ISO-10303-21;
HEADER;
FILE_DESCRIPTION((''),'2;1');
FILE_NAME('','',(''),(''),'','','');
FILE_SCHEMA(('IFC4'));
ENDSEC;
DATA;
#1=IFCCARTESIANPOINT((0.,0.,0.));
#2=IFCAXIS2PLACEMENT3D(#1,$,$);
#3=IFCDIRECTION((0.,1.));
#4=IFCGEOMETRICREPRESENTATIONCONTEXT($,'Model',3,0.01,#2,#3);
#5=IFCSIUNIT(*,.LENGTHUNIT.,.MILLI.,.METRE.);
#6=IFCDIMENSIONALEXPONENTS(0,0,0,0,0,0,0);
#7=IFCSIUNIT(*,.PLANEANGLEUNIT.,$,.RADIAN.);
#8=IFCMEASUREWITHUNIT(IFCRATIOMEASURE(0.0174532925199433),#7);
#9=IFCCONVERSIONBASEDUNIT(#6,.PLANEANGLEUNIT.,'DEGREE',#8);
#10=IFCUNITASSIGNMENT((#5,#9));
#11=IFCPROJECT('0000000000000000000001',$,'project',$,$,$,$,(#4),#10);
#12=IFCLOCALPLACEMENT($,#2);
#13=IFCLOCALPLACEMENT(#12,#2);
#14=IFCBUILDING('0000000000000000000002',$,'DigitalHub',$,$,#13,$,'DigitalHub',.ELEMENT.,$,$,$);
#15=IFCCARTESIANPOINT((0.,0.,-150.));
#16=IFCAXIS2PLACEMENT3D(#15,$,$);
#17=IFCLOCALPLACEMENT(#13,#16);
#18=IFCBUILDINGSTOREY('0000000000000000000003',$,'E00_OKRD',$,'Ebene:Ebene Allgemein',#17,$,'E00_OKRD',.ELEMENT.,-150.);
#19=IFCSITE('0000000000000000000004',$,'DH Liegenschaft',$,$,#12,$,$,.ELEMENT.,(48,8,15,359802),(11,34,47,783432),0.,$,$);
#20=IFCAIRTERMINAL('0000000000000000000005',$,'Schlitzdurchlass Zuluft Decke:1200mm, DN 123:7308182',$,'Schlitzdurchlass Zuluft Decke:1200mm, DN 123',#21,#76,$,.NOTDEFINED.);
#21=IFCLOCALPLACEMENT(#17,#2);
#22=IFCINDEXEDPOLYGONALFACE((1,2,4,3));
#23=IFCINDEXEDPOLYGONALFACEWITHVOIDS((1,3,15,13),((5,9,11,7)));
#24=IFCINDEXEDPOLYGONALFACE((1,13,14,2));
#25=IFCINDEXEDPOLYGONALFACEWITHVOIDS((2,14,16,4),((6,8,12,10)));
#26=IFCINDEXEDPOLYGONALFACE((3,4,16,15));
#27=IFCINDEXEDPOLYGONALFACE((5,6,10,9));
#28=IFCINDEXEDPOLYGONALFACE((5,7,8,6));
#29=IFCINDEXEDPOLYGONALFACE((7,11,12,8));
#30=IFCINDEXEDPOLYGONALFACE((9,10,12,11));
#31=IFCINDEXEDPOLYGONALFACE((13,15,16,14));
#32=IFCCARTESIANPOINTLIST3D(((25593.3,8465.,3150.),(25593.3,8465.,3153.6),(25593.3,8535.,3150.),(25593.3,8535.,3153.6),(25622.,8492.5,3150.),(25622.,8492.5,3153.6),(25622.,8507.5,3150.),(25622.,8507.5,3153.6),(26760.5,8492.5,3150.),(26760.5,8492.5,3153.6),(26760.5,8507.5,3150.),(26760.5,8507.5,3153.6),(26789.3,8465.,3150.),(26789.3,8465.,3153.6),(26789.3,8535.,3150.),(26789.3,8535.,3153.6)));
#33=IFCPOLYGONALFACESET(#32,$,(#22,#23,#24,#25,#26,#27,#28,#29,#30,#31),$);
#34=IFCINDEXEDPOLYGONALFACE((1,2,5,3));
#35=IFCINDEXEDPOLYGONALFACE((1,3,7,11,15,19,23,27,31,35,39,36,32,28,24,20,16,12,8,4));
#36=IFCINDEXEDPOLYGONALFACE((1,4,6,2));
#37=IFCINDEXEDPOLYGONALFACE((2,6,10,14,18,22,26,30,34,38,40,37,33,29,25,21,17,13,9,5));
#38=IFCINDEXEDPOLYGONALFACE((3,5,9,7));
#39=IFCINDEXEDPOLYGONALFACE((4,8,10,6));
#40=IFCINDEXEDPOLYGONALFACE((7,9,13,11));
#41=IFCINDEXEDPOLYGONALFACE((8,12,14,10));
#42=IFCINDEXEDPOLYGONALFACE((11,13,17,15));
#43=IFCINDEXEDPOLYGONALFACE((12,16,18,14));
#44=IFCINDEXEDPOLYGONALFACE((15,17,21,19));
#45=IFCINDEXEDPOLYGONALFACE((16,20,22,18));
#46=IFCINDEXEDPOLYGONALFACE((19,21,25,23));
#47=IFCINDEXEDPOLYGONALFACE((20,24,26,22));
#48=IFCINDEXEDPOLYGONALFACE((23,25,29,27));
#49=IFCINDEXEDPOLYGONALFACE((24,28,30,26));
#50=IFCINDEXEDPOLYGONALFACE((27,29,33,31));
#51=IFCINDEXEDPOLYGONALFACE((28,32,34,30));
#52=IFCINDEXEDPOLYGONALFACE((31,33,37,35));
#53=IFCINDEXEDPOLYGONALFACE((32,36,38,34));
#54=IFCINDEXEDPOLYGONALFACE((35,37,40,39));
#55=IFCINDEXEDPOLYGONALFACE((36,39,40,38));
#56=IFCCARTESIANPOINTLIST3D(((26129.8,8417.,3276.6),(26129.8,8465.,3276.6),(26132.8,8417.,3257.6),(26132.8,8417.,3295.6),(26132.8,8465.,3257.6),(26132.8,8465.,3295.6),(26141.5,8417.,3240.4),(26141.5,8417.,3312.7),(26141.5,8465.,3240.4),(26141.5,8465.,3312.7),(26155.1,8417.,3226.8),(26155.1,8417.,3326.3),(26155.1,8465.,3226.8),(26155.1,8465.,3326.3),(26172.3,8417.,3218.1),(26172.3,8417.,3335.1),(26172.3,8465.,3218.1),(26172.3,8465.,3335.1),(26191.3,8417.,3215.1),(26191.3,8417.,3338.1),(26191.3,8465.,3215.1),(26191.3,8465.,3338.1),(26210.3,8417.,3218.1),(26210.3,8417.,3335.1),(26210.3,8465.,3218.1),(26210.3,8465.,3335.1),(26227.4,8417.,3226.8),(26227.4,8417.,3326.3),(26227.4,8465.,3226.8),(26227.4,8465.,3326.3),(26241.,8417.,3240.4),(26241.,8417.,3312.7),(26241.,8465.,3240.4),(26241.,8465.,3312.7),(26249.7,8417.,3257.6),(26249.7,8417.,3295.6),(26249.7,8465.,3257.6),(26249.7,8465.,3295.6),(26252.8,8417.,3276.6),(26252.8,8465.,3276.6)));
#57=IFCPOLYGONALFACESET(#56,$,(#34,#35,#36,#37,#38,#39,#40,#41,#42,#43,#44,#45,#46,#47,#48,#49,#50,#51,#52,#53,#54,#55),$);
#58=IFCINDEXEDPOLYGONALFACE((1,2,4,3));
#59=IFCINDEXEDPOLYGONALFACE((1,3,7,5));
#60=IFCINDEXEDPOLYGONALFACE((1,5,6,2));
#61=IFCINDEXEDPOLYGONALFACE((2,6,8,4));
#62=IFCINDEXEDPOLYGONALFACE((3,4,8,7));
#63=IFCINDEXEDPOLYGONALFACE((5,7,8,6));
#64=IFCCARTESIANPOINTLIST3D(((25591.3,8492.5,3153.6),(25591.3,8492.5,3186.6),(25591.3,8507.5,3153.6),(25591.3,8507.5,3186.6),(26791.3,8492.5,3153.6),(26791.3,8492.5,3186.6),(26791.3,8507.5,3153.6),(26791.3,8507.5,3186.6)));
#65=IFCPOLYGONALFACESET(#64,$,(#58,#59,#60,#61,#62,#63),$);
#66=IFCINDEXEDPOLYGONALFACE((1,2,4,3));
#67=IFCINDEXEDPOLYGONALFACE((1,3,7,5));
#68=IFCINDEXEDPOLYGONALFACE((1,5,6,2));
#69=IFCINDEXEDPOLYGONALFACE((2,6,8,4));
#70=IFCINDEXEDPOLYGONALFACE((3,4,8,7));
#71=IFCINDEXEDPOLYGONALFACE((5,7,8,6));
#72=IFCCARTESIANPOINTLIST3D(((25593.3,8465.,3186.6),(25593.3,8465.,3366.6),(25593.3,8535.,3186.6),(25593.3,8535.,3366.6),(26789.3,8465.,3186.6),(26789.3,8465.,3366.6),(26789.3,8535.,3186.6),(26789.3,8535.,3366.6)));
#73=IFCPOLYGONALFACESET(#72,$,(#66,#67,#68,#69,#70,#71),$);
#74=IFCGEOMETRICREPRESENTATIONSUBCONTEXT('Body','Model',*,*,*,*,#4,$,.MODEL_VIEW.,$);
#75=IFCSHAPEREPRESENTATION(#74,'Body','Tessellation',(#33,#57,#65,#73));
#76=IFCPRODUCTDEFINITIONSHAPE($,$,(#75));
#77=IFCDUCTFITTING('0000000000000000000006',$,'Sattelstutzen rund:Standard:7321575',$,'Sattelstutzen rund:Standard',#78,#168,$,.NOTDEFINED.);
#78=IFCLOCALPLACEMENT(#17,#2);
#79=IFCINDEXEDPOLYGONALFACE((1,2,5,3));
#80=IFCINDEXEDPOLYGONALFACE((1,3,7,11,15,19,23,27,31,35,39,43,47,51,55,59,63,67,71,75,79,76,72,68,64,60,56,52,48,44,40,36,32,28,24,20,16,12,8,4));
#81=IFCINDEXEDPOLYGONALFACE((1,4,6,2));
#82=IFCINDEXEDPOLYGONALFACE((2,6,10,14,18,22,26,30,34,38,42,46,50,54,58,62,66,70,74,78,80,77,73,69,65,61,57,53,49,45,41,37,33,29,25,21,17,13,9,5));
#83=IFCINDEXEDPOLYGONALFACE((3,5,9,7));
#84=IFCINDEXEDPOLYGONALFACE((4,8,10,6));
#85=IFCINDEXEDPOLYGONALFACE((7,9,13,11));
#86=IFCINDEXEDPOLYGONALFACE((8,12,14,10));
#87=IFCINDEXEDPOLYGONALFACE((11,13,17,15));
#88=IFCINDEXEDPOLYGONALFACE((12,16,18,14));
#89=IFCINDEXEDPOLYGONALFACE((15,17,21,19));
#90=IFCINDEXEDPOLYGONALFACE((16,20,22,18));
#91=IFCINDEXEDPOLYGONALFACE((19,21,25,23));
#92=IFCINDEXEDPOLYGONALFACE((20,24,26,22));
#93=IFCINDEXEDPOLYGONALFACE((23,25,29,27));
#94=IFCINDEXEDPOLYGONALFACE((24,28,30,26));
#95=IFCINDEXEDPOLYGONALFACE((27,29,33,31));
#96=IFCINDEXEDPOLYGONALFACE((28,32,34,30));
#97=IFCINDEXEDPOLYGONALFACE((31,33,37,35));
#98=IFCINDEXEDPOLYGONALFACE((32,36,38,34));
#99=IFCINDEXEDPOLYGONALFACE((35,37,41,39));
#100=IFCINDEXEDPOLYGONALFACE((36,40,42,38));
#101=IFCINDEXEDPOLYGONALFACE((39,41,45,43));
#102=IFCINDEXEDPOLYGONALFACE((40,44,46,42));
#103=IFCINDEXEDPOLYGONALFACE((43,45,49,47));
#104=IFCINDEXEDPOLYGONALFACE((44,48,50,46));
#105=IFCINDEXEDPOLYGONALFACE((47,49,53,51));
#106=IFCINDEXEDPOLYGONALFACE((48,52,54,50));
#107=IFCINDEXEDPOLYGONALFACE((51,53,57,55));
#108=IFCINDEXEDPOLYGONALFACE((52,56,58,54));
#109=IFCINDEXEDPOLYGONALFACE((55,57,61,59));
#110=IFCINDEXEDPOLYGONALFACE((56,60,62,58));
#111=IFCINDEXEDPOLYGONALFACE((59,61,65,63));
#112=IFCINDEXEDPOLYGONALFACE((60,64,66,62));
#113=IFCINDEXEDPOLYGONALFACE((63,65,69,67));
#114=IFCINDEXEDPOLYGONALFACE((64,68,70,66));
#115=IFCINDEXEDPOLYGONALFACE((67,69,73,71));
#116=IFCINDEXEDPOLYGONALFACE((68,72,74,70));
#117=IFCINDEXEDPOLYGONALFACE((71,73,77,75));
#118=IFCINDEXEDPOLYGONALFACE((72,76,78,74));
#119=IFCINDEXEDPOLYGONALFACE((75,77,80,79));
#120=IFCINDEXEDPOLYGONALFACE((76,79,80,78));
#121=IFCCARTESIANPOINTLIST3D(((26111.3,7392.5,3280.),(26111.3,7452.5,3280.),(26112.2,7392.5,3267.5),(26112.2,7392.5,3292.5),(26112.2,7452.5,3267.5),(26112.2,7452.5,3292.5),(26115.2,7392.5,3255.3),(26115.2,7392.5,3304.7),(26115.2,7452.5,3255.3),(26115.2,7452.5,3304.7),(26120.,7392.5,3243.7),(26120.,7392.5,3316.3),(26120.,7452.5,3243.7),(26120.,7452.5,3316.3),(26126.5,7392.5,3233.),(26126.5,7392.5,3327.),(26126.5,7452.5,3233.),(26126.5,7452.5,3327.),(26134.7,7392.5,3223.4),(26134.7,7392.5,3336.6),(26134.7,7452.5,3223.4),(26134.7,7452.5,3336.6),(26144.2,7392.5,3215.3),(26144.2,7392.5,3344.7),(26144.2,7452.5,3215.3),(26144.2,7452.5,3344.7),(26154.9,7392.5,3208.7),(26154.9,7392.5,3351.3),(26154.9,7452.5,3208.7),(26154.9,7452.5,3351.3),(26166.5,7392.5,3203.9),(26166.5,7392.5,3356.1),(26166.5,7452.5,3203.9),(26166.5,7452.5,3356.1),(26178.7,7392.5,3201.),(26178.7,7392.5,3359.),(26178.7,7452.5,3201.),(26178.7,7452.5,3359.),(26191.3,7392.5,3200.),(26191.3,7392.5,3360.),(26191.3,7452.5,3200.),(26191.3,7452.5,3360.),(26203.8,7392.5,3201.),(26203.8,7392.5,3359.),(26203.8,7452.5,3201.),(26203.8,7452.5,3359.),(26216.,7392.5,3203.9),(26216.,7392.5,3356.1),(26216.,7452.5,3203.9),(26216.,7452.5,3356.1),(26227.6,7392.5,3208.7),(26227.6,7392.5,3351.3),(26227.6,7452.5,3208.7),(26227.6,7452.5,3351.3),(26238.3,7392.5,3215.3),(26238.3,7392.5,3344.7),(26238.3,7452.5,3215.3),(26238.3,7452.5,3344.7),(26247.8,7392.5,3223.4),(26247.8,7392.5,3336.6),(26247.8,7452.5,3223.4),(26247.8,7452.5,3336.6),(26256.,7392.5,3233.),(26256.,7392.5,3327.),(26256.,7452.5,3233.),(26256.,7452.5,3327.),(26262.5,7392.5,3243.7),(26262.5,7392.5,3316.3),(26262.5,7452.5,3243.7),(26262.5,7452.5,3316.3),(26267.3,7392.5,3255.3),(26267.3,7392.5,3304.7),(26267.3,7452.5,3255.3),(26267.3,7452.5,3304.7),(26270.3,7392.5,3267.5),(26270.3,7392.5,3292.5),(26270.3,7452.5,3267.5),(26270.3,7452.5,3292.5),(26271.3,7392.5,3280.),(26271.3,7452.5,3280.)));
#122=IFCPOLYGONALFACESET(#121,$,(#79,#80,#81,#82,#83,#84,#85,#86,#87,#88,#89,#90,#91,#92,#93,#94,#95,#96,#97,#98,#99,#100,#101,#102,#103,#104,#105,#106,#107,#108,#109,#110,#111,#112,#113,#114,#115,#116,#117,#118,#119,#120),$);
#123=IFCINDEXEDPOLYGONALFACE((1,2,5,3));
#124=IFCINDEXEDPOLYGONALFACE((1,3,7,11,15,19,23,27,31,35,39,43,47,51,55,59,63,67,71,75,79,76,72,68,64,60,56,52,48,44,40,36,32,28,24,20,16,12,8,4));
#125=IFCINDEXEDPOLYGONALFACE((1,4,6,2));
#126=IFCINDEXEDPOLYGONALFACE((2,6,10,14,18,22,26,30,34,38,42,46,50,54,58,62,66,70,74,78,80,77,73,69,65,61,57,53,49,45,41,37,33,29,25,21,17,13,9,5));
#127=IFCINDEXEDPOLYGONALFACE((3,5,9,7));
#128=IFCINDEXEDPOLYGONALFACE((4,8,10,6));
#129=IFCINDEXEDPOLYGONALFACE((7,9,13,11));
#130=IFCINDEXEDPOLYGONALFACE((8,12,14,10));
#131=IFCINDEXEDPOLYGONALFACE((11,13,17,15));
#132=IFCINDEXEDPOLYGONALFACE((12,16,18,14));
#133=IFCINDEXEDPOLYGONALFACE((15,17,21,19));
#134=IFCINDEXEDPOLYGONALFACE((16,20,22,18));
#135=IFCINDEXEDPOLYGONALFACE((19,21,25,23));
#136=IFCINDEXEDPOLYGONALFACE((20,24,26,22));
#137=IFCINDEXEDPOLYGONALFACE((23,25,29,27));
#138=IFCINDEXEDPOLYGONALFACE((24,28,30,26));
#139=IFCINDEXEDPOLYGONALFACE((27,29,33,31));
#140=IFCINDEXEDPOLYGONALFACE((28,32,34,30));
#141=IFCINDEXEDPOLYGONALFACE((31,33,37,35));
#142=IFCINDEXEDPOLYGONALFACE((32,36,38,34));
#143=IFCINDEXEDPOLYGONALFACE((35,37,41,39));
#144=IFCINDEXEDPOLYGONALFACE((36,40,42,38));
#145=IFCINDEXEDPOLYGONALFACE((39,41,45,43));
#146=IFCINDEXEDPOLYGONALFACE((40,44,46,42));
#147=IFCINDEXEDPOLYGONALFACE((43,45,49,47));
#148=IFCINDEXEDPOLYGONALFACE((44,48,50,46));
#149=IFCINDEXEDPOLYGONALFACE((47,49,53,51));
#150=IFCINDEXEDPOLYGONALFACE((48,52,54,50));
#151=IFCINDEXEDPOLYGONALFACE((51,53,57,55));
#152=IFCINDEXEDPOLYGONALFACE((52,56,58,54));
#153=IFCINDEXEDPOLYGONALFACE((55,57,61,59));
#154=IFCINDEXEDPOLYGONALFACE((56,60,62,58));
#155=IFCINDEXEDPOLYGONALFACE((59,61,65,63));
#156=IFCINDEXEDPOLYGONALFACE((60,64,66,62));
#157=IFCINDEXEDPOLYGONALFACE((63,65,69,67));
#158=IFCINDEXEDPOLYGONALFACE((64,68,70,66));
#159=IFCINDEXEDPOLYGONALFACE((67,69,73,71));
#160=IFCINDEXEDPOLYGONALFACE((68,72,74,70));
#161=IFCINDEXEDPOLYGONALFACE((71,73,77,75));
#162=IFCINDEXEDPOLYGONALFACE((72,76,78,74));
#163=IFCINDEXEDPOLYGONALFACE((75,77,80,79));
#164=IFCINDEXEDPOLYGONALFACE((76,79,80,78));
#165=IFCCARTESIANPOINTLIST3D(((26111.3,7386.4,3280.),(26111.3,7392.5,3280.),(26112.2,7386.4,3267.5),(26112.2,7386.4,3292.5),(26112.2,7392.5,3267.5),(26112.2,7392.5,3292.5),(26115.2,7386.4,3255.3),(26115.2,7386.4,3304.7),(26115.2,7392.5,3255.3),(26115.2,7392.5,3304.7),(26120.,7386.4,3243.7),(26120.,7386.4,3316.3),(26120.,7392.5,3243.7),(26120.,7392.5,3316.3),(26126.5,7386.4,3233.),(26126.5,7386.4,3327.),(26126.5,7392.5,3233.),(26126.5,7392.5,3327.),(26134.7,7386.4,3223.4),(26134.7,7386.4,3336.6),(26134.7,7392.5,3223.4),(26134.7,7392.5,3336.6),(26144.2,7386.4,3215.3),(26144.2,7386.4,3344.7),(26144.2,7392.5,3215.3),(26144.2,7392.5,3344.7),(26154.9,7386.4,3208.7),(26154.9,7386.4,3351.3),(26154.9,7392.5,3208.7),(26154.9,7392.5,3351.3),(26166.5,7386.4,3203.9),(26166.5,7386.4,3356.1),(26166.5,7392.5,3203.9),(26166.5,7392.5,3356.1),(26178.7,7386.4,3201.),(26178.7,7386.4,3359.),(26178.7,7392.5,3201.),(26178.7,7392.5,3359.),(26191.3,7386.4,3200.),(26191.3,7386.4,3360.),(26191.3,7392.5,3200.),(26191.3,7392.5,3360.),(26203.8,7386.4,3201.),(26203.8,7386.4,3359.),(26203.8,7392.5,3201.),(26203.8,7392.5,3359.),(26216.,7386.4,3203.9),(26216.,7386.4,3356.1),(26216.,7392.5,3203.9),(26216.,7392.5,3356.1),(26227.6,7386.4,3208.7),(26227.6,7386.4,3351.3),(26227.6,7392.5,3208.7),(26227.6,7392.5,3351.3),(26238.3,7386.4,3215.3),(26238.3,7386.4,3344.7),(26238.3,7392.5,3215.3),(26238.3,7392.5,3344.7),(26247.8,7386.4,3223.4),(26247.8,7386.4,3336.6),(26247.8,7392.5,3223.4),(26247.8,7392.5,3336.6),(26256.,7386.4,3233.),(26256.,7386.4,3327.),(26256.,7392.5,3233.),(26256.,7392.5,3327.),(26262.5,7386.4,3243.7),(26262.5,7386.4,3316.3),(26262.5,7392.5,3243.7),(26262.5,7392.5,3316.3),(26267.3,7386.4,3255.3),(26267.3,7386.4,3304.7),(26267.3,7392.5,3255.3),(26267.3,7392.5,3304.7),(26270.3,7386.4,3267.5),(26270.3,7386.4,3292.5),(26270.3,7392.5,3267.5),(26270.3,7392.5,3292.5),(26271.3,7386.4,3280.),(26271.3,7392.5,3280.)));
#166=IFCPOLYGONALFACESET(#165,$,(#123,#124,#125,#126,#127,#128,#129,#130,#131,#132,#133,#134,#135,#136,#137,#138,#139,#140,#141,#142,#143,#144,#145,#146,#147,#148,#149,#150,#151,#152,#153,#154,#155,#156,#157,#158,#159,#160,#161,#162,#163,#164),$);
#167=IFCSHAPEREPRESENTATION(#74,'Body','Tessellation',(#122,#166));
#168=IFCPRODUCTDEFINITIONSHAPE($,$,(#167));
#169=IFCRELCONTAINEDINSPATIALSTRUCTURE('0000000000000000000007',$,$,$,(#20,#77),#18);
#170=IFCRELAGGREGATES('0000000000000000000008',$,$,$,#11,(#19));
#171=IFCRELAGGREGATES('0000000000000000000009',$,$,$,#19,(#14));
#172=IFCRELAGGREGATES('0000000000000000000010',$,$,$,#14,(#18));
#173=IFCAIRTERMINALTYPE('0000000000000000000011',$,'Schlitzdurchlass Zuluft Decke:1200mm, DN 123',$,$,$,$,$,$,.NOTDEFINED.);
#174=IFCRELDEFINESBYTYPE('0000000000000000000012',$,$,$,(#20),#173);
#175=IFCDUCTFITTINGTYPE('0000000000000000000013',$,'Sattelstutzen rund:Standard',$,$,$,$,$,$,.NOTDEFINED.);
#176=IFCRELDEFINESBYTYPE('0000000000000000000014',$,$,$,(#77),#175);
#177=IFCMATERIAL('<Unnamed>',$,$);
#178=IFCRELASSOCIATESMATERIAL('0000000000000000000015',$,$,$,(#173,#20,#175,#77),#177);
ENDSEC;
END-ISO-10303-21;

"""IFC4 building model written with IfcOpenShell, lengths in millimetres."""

from ifc_helpers import new_model, entity, si_unit, converted_unit, direction, frame, origin, place, context, subcontext, project, spatial, indexed_curve, outline, extrude, source, transform, mapped, material, type_object, type_shapes, element, save


model = new_model("IFC4")

# Units and contexts
model_context = context("Model", 3, precision=0.01, world=origin(), true_north=direction((0.0, 1.0)))
body_context = subcontext(model_context, "Body", "Model", "MODEL_VIEW")
ifc_project = project(units=[si_unit("LENGTHUNIT", "METRE", prefix="MILLI"), converted_unit("PLANEANGLEUNIT", "DEGREE", entity("IfcRatioMeasure", 0.0174532925199433), si_unit("PLANEANGLEUNIT", "RADIAN"), dimensions=[0, 0, 0, 0, 0, 0, 0])], contexts=[model_context])

# Site, building, storey
site_placement = place(None, origin())
site = spatial("IfcSite", under=ifc_project, at=site_placement, Name="DH Liegenschaft", CompositionType="ELEMENT", RefLatitude=(48, 8, 15, 359802), RefLongitude=(11, 34, 47, 783432), RefElevation=0.0)
building_placement = place(site_placement, origin())
building = spatial("IfcBuilding", under=site, at=building_placement, Name="DigitalHub", LongName="DigitalHub", CompositionType="ELEMENT")
storey_placement = place(building_placement, frame((0.0, 0.0, -150.0)))
storey = spatial("IfcBuildingStorey", under=building, at=storey_placement, Name="E00_OKRD", ObjectType="Ebene:Ebene Allgemein", LongName="E00_OKRD", CompositionType="ELEMENT", Elevation=-150.0)

# Air terminal
ifc_material_1 = material(Name="<Unnamed>")
air_terminal_type_1 = type_object("IfcAirTerminalType", Name="Schlitzdurchlass Zuluft Decke:1200mm, DN 123", PredefinedType="NOTDEFINED", material=ifc_material_1)
shared_shape_1 = source(origin(), body_context, "Body", "SweptSolid", [
    extrude(outline(indexed_curve([(-598.0, -35.0), (598.0, -35.0), (598.0, 35.0), (-598.0, 35.0), (-598.0, -35.0)], self_intersect=False), holes=[indexed_curve([(-569.2, -7.5), (-569.2, 7.5), (569.2, 7.5), (569.2, -7.5), (-569.2, -7.5)], self_intersect=False)]), frame((600.0, 35.0, 0.0), z_axis=(0.0, 0.0, 1.0), x_axis=(-1.0, 0.0, 0.0)), (0.0, 0.0, 1.0), 3.6),
    extrude(outline(indexed_curve([(61.5, 0.0), (58.5, 19.0), (49.8, 36.1), (36.1, 49.8), (19.0, 58.5), (0.0, 61.5), (-19.0, 58.5), (-36.1, 49.8), (-49.8, 36.1), (-58.5, 19.0), (-61.5, 0.0), (-58.5, -19.0), (-49.8, -36.1), (-36.1, -49.8), (-19.0, -58.5), (0.0, -61.5), (19.0, -58.5), (36.1, -49.8), (49.8, -36.1), (58.5, -19.0), (61.5, 0.0)], self_intersect=False)), frame((600.0, 70.0, 126.6), z_axis=(0.0, 1.0, 0.0), x_axis=(-1.0, 0.0, 0.0)), (0.0, 0.0, 1.0), 48.0),
    extrude(outline(indexed_curve([(-600.0, -7.5), (600.0, -7.5), (600.0, 7.5), (-600.0, 7.5), (-600.0, -7.5)], self_intersect=False)), frame((600.0, 35.0, 3.6), z_axis=(0.0, 0.0, 1.0), x_axis=(-1.0, 0.0, 0.0)), (0.0, 0.0, 1.0), 33.0),
    extrude(outline(indexed_curve([(-598.0, -35.0), (598.0, -35.0), (598.0, 35.0), (-598.0, 35.0), (-598.0, -35.0)], self_intersect=False)), frame((600.0, 35.0, 36.6), z_axis=(0.0, 0.0, 1.0), x_axis=(-1.0, 0.0, 0.0)), (0.0, 0.0, 1.0), 180.0),
])
type_shapes(air_terminal_type_1, [shared_shape_1])
air_terminal_1_placement = place(storey_placement, frame((26791.3, 8535.0, 3150.0), z_axis=(0.0, 0.0, 1.0), x_axis=(-1.0, 0.0, 0.0)))
element("IfcAirTerminal", 1, at=air_terminal_1_placement, inside=storey, type_object=air_terminal_type_1, material=ifc_material_1, Name="Schlitzdurchlass Zuluft Decke:1200mm, DN 123:7308182", ObjectType="Schlitzdurchlass Zuluft Decke:1200mm, DN 123", PredefinedType="NOTDEFINED", context=body_context, shape_type="MappedRepresentation", body=[
    mapped(shared_shape_1, transform((0.0, 0.0, 0.0), scale=1.0)),
])

# Duct fitting
duct_fitting_type_1 = type_object("IfcDuctFittingType", Name="Sattelstutzen rund:Standard", PredefinedType="NOTDEFINED", material=ifc_material_1)
shared_shape_2 = source(origin(), body_context, "Body", "SweptSolid", [
    extrude(outline(indexed_curve([(0.0, -80.0), (12.5, -79.0), (24.7, -76.1), (36.3, -71.3), (47.0, -64.7), (56.6, -56.6), (64.7, -47.0), (71.3, -36.3), (76.1, -24.7), (79.0, -12.5), (80.0, 0.0), (79.0, 12.5), (76.1, 24.7), (71.3, 36.3), (64.7, 47.0), (56.6, 56.6), (47.0, 64.7), (36.3, 71.3), (24.7, 76.1), (12.5, 79.0), (0.0, 80.0), (-12.5, 79.0), (-24.7, 76.1), (-36.3, 71.3), (-47.0, 64.7), (-56.6, 56.6), (-64.7, 47.0), (-71.3, 36.3), (-76.1, 24.7), (-79.0, 12.5), (-80.0, 0.0), (-79.0, -12.5), (-76.1, -24.7), (-71.3, -36.3), (-64.7, -47.0), (-56.6, -56.6), (-47.0, -64.7), (-36.3, -71.3), (-24.7, -76.1), (-12.5, -79.0), (0.0, -80.0)], self_intersect=False)), frame((0.0, 0.0, 0.0), z_axis=(1.0, 0.0, 0.0), x_axis=(0.0, -1.0, 0.0)), (0.0, 0.0, 1.0), 60.0),
    extrude(outline(indexed_curve([(0.0, -80.0), (12.5, -79.0), (24.7, -76.1), (36.3, -71.3), (47.0, -64.7), (56.6, -56.6), (64.7, -47.0), (71.3, -36.3), (76.1, -24.7), (79.0, -12.5), (80.0, 0.0), (79.0, 12.5), (76.1, 24.7), (71.3, 36.3), (64.7, 47.0), (56.6, 56.6), (47.0, 64.7), (36.3, 71.3), (24.7, 76.1), (12.5, 79.0), (0.0, 80.0), (-12.5, 79.0), (-24.7, 76.1), (-36.3, 71.3), (-47.0, 64.7), (-56.6, 56.6), (-64.7, 47.0), (-71.3, 36.3), (-76.1, 24.7), (-79.0, 12.5), (-80.0, 0.0), (-79.0, -12.5), (-76.1, -24.7), (-71.3, -36.3), (-64.7, -47.0), (-56.6, -56.6), (-47.0, -64.7), (-36.3, -71.3), (-24.7, -76.1), (-12.5, -79.0), (0.0, -80.0)], self_intersect=False)), frame((-6.1, 0.0, 0.0), z_axis=(1.0, 0.0, 0.0), x_axis=(0.0, -1.0, 0.0)), (0.0, 0.0, 1.0), 6.1),
])
type_shapes(duct_fitting_type_1, [shared_shape_2])
duct_fitting_1_placement = place(storey_placement, frame((26191.3, 7392.5, 3280.0), z_axis=(0.0, 0.0, -1.0), x_axis=(0.0, 1.0, 0.0)))
element("IfcDuctFitting", 2, at=duct_fitting_1_placement, inside=storey, type_object=duct_fitting_type_1, material=ifc_material_1, Name="Sattelstutzen rund:Standard:7321575", ObjectType="Sattelstutzen rund:Standard", PredefinedType="NOTDEFINED", context=body_context, shape_type="MappedRepresentation", body=[
    mapped(shared_shape_2, transform((0.0, 0.0, 0.0), scale=1.0)),
])

save(model, "model.ifc")
